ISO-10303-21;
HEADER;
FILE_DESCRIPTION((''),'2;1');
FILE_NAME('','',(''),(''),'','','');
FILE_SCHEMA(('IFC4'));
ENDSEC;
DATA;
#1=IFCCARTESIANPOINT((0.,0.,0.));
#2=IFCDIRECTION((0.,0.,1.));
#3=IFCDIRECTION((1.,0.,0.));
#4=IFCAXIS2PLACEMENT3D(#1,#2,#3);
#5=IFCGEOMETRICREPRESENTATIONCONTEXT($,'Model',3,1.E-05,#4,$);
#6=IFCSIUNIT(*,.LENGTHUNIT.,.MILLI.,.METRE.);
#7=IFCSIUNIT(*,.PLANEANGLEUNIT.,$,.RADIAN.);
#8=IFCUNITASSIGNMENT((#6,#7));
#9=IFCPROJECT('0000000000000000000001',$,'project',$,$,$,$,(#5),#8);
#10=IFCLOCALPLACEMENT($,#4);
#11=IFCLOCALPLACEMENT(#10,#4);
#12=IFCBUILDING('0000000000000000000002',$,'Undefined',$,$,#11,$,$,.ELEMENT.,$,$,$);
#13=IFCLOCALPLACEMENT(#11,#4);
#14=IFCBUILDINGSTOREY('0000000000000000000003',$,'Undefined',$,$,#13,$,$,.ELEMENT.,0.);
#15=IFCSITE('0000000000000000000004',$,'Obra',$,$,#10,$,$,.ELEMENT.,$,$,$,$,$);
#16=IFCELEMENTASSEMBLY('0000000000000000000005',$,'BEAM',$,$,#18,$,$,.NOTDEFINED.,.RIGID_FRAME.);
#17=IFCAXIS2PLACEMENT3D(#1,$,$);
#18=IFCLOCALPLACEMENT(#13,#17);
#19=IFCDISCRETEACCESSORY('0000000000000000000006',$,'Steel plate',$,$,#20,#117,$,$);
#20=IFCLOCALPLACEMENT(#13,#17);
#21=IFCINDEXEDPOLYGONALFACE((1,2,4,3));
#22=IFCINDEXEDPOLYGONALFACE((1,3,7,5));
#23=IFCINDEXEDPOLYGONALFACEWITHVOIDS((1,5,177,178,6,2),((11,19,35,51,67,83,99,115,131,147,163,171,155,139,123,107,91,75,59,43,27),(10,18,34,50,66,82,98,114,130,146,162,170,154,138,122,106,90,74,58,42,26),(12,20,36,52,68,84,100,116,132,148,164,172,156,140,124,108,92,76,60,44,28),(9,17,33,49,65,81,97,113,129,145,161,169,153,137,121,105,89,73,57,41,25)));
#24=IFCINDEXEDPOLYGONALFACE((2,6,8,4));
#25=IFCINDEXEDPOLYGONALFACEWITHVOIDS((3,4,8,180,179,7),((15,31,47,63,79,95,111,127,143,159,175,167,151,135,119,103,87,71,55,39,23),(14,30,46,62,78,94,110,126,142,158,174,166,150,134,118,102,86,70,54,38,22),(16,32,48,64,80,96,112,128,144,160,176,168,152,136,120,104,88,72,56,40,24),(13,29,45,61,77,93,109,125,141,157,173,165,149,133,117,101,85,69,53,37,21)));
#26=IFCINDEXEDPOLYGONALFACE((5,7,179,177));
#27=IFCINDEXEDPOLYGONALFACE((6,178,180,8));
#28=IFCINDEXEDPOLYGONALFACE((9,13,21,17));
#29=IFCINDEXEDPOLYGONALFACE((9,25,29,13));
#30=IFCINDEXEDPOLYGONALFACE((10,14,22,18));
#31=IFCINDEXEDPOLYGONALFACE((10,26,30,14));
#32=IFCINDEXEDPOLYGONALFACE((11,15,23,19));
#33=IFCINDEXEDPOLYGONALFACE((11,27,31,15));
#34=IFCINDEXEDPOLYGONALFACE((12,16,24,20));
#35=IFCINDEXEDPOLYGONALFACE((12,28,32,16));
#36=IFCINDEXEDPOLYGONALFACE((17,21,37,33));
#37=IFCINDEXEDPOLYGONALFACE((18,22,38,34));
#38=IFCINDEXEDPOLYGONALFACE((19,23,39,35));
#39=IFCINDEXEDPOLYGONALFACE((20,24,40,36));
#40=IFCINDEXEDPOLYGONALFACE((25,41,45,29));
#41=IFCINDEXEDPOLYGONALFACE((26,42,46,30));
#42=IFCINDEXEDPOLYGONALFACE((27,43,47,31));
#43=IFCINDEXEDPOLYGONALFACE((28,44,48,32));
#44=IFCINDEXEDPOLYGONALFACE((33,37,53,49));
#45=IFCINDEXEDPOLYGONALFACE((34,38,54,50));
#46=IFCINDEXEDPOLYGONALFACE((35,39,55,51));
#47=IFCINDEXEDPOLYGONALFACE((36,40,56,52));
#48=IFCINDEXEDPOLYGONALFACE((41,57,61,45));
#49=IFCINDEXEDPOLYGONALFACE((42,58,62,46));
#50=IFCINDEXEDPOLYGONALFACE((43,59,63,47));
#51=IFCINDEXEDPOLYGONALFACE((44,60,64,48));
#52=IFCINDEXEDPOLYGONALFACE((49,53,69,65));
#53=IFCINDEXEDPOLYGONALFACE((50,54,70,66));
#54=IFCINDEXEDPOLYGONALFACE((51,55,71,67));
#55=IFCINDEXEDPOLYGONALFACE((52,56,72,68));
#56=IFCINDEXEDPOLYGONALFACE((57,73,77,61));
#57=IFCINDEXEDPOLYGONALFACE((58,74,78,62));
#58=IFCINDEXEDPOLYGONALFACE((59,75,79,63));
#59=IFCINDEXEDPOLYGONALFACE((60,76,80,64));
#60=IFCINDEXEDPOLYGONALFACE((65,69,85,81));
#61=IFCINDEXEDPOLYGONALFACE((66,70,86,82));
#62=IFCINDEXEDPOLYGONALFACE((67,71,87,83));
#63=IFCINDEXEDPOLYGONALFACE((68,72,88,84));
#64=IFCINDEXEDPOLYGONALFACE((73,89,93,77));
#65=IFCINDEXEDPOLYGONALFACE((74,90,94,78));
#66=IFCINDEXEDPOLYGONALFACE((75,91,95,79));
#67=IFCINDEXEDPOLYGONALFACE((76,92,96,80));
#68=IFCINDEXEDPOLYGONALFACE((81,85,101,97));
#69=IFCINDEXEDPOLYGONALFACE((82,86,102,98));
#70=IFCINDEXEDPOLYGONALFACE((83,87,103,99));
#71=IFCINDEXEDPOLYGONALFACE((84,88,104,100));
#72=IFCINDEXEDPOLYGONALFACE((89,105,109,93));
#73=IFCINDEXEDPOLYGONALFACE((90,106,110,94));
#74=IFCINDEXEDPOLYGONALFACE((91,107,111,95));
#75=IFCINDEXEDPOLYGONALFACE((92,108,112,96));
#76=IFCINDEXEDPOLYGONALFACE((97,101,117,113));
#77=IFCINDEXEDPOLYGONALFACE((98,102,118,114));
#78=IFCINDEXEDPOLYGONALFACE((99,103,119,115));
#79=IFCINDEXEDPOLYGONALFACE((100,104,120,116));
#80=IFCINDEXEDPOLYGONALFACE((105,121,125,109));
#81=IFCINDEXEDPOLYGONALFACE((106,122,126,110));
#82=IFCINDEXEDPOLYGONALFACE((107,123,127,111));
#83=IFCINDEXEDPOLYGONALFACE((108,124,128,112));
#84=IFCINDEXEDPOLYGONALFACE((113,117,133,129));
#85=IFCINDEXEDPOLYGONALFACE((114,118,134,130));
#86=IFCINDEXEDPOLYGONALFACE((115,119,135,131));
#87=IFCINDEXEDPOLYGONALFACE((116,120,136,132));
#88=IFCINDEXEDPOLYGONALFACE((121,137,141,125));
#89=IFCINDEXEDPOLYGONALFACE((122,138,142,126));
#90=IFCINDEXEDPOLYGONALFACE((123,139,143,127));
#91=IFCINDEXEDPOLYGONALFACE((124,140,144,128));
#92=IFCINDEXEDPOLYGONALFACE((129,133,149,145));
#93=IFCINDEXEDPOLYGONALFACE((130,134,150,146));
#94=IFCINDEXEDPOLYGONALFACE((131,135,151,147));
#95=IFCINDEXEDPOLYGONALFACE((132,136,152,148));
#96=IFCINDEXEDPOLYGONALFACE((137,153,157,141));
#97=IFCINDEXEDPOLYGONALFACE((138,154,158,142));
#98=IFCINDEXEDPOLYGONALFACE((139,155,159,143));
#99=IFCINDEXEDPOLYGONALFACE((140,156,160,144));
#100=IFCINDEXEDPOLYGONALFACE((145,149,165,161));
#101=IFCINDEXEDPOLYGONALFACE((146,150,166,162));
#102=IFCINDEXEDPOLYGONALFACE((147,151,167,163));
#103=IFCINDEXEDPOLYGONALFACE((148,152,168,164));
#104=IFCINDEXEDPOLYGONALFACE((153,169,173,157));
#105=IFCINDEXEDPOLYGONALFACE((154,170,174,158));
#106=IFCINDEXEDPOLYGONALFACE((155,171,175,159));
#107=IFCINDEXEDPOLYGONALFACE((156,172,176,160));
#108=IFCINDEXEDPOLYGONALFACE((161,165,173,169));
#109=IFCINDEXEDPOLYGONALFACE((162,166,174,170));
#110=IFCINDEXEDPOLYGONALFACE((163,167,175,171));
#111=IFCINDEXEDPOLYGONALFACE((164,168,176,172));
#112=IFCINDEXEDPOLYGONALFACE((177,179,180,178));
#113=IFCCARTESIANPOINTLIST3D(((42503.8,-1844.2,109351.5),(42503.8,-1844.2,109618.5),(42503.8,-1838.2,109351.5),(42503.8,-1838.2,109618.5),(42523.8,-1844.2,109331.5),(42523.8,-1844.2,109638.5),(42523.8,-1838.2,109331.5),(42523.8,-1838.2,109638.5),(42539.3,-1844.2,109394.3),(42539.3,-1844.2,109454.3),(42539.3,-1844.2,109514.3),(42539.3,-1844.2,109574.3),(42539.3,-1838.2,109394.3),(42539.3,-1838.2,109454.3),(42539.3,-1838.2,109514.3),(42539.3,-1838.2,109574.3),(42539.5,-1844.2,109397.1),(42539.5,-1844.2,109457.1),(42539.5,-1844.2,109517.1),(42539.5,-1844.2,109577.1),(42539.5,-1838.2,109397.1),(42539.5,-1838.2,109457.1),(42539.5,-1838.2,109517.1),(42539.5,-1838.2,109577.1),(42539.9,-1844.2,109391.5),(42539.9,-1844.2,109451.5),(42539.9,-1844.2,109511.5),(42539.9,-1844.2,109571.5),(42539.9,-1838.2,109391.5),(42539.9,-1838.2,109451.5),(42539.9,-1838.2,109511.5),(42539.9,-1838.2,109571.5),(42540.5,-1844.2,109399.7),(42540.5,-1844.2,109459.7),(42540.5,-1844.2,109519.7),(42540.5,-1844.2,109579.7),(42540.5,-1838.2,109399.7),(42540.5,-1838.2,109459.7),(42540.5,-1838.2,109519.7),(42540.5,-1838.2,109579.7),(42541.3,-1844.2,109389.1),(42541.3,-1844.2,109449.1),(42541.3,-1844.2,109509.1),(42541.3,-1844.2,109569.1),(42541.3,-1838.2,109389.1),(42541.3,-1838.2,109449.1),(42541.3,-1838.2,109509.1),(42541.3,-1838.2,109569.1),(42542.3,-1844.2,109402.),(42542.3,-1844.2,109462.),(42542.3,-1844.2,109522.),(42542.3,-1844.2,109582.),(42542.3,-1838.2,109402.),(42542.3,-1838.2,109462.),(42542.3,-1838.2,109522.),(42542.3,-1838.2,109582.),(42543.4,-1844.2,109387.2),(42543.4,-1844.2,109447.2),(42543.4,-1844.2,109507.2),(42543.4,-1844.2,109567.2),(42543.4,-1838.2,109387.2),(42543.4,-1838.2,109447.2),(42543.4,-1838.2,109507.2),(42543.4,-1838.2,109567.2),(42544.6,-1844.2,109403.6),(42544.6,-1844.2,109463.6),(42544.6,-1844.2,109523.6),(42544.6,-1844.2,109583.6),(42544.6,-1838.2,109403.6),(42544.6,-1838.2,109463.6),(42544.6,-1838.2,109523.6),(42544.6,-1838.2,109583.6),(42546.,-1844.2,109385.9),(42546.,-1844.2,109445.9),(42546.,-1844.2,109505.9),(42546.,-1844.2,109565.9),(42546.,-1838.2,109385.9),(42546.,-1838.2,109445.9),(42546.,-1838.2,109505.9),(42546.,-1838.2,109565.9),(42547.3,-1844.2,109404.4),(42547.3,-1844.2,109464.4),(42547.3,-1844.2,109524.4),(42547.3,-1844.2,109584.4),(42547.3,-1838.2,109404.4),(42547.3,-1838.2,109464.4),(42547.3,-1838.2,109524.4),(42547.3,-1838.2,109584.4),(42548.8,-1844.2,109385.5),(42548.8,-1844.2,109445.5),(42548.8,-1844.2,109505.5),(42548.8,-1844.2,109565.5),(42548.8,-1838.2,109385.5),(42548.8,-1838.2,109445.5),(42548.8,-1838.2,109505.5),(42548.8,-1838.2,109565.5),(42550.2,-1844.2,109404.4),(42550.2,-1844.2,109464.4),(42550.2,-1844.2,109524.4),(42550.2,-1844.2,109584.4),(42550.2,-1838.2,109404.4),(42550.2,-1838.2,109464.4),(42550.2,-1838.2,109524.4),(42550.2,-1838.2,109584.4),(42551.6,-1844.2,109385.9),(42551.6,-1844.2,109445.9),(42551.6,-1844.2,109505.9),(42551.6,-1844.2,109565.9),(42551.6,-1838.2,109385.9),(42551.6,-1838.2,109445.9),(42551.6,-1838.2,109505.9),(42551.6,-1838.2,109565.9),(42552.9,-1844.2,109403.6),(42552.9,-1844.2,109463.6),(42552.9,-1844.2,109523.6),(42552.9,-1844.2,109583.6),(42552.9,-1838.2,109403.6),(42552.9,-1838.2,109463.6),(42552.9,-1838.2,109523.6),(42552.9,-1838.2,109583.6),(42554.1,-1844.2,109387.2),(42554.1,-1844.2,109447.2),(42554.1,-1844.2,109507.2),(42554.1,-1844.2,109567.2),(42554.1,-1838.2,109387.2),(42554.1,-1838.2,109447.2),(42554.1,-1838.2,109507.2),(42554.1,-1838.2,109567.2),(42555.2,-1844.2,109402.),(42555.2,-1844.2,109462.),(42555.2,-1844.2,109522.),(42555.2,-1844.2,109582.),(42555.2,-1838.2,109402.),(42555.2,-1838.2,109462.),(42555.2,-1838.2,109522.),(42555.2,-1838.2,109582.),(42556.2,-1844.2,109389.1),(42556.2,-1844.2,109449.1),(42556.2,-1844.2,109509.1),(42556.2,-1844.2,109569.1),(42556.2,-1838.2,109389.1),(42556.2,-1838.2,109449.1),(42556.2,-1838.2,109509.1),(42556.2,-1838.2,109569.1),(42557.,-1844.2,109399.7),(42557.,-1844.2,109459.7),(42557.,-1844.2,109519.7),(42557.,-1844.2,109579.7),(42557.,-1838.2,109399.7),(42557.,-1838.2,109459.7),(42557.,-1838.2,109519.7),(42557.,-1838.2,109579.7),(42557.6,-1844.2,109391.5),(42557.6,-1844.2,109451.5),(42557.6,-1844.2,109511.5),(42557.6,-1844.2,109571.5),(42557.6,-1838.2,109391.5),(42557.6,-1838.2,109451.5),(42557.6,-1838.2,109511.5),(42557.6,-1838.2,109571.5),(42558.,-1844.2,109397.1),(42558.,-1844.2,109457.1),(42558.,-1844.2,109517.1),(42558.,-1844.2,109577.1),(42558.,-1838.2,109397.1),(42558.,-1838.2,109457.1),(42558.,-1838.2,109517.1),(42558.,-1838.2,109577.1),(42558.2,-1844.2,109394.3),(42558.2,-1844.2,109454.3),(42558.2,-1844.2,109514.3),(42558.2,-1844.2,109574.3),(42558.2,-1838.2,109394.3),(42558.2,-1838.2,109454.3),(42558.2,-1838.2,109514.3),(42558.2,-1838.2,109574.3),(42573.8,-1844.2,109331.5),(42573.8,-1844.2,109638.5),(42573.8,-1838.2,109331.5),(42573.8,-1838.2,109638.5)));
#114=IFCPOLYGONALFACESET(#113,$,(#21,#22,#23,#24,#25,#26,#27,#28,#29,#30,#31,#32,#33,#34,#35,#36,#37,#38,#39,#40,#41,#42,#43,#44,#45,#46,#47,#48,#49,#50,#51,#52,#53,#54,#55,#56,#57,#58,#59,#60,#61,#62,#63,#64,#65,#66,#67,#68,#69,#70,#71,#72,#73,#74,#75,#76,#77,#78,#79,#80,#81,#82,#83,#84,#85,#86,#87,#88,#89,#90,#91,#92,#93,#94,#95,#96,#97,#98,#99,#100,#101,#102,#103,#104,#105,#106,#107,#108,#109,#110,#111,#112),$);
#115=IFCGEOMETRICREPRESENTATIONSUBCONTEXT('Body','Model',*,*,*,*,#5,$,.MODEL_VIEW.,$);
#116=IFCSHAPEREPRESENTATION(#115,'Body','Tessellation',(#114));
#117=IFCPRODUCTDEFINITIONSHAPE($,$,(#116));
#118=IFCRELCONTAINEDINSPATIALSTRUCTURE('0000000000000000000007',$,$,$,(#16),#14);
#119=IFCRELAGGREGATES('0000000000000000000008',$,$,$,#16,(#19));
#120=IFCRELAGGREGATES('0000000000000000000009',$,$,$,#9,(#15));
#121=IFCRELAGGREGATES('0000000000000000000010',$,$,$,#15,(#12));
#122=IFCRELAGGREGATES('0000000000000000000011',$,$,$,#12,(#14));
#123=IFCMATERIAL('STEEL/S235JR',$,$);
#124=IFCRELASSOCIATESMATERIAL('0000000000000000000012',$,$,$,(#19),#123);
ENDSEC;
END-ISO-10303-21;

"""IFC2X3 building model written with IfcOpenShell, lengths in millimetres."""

from ifc_helpers import new_model, si_unit, frame, origin_with_axes, origin_2d_with_axis, place, context, subcontext, project, spatial, polyline, circle, outline, extrude, source, transform, mapped, material, element, aggregate, save


model = new_model("IFC2X3")

# Units and contexts
model_context = context("Model", 3, precision=1e-05, world=origin_with_axes())
body_context = subcontext(model_context, "Body", "Model", "MODEL_VIEW")
ifc_project = project(units=[si_unit("LENGTHUNIT", "METRE", prefix="MILLI"), si_unit("PLANEANGLEUNIT", "RADIAN")], contexts=[model_context])

# Site, building, storey
site_placement = place(None, origin_with_axes())
site = spatial("IfcSite", under=ifc_project, at=site_placement, Name="Obra", CompositionType="ELEMENT")
building_placement = place(site_placement, origin_with_axes())
building = spatial("IfcBuilding", under=site, at=building_placement, Name="Undefined", CompositionType="ELEMENT")
storey_placement = place(building_placement, origin_with_axes())
storey = spatial("IfcBuildingStorey", under=building, at=storey_placement, Name="Undefined", CompositionType="ELEMENT", Elevation=0.0)

# Element assembly, discrete accessory, opening
ifc_material = material(Name="STEEL/S235JR")
shared_shape = source(origin_with_axes(), body_context, "Body", "SweptSolid", [
    extrude(circle(Radius=9.5, at=origin_2d_with_axis()), frame((0.0, -9.8, 0.0), z_axis=(0.0, 1.0, 0.0), x_axis=(1.0, 0.0, 0.0)), (0.0, 0.0, 1.0), 6.2),
])
assembly_1_placement = place(storey_placement, origin_with_axes())
assembly_1 = element("IfcElementAssembly", 1, at=assembly_1_placement, inside=storey, Name="BEAM", AssemblyPlace="NOTDEFINED", PredefinedType="RIGID_FRAME")
discrete_accessory_1_placement = place(assembly_1_placement, frame((42573.8, -1841.2, 109331.5), z_axis=(0.000012, 1.0, 0.0), x_axis=(-1.0, 0.000012, 0.0)))
discrete_accessory_1 = element("IfcDiscreteAccessory", 2, at=discrete_accessory_1_placement, material=ifc_material, Name="Steel plate", context=body_context, shape_type="SweptSolid", body=[
    extrude(outline(polyline([(0.0, 0.0), (50.0, 0.0), (70.0, 20.0), (70.0, 287.0), (50.0, 307.0), (0.0, 307.0), (0.0, 0.0)])), frame((0.0, 0.0, -3.0), z_axis=(0.0, 0.0, 1.0), x_axis=(1.0, 0.0, 0.0)), (0.0, 0.0, 1.0), 6.0),
])
opening_1_placement = place(assembly_1_placement, frame((42513.8, -1834.4, 109650.0), z_axis=(1.0, -0.000012, 0.0), x_axis=(0.0, 0.0, -1.0)))
element("IfcOpeningElement", 3, at=opening_1_placement, cuts=discrete_accessory_1, ObjectType="Opening", context=body_context, shape_type="MappedRepresentation", body=[
    mapped(shared_shape, transform((75.0, 0.0, 35.0))),
    mapped(shared_shape, transform((135.0, 0.0, 35.0))),
    mapped(shared_shape, transform((195.0, 0.0, 35.0))),
    mapped(shared_shape, transform((255.0, 0.0, 35.0))),
])
aggregate(assembly_1, [discrete_accessory_1])

save(model, "model.ifc")
